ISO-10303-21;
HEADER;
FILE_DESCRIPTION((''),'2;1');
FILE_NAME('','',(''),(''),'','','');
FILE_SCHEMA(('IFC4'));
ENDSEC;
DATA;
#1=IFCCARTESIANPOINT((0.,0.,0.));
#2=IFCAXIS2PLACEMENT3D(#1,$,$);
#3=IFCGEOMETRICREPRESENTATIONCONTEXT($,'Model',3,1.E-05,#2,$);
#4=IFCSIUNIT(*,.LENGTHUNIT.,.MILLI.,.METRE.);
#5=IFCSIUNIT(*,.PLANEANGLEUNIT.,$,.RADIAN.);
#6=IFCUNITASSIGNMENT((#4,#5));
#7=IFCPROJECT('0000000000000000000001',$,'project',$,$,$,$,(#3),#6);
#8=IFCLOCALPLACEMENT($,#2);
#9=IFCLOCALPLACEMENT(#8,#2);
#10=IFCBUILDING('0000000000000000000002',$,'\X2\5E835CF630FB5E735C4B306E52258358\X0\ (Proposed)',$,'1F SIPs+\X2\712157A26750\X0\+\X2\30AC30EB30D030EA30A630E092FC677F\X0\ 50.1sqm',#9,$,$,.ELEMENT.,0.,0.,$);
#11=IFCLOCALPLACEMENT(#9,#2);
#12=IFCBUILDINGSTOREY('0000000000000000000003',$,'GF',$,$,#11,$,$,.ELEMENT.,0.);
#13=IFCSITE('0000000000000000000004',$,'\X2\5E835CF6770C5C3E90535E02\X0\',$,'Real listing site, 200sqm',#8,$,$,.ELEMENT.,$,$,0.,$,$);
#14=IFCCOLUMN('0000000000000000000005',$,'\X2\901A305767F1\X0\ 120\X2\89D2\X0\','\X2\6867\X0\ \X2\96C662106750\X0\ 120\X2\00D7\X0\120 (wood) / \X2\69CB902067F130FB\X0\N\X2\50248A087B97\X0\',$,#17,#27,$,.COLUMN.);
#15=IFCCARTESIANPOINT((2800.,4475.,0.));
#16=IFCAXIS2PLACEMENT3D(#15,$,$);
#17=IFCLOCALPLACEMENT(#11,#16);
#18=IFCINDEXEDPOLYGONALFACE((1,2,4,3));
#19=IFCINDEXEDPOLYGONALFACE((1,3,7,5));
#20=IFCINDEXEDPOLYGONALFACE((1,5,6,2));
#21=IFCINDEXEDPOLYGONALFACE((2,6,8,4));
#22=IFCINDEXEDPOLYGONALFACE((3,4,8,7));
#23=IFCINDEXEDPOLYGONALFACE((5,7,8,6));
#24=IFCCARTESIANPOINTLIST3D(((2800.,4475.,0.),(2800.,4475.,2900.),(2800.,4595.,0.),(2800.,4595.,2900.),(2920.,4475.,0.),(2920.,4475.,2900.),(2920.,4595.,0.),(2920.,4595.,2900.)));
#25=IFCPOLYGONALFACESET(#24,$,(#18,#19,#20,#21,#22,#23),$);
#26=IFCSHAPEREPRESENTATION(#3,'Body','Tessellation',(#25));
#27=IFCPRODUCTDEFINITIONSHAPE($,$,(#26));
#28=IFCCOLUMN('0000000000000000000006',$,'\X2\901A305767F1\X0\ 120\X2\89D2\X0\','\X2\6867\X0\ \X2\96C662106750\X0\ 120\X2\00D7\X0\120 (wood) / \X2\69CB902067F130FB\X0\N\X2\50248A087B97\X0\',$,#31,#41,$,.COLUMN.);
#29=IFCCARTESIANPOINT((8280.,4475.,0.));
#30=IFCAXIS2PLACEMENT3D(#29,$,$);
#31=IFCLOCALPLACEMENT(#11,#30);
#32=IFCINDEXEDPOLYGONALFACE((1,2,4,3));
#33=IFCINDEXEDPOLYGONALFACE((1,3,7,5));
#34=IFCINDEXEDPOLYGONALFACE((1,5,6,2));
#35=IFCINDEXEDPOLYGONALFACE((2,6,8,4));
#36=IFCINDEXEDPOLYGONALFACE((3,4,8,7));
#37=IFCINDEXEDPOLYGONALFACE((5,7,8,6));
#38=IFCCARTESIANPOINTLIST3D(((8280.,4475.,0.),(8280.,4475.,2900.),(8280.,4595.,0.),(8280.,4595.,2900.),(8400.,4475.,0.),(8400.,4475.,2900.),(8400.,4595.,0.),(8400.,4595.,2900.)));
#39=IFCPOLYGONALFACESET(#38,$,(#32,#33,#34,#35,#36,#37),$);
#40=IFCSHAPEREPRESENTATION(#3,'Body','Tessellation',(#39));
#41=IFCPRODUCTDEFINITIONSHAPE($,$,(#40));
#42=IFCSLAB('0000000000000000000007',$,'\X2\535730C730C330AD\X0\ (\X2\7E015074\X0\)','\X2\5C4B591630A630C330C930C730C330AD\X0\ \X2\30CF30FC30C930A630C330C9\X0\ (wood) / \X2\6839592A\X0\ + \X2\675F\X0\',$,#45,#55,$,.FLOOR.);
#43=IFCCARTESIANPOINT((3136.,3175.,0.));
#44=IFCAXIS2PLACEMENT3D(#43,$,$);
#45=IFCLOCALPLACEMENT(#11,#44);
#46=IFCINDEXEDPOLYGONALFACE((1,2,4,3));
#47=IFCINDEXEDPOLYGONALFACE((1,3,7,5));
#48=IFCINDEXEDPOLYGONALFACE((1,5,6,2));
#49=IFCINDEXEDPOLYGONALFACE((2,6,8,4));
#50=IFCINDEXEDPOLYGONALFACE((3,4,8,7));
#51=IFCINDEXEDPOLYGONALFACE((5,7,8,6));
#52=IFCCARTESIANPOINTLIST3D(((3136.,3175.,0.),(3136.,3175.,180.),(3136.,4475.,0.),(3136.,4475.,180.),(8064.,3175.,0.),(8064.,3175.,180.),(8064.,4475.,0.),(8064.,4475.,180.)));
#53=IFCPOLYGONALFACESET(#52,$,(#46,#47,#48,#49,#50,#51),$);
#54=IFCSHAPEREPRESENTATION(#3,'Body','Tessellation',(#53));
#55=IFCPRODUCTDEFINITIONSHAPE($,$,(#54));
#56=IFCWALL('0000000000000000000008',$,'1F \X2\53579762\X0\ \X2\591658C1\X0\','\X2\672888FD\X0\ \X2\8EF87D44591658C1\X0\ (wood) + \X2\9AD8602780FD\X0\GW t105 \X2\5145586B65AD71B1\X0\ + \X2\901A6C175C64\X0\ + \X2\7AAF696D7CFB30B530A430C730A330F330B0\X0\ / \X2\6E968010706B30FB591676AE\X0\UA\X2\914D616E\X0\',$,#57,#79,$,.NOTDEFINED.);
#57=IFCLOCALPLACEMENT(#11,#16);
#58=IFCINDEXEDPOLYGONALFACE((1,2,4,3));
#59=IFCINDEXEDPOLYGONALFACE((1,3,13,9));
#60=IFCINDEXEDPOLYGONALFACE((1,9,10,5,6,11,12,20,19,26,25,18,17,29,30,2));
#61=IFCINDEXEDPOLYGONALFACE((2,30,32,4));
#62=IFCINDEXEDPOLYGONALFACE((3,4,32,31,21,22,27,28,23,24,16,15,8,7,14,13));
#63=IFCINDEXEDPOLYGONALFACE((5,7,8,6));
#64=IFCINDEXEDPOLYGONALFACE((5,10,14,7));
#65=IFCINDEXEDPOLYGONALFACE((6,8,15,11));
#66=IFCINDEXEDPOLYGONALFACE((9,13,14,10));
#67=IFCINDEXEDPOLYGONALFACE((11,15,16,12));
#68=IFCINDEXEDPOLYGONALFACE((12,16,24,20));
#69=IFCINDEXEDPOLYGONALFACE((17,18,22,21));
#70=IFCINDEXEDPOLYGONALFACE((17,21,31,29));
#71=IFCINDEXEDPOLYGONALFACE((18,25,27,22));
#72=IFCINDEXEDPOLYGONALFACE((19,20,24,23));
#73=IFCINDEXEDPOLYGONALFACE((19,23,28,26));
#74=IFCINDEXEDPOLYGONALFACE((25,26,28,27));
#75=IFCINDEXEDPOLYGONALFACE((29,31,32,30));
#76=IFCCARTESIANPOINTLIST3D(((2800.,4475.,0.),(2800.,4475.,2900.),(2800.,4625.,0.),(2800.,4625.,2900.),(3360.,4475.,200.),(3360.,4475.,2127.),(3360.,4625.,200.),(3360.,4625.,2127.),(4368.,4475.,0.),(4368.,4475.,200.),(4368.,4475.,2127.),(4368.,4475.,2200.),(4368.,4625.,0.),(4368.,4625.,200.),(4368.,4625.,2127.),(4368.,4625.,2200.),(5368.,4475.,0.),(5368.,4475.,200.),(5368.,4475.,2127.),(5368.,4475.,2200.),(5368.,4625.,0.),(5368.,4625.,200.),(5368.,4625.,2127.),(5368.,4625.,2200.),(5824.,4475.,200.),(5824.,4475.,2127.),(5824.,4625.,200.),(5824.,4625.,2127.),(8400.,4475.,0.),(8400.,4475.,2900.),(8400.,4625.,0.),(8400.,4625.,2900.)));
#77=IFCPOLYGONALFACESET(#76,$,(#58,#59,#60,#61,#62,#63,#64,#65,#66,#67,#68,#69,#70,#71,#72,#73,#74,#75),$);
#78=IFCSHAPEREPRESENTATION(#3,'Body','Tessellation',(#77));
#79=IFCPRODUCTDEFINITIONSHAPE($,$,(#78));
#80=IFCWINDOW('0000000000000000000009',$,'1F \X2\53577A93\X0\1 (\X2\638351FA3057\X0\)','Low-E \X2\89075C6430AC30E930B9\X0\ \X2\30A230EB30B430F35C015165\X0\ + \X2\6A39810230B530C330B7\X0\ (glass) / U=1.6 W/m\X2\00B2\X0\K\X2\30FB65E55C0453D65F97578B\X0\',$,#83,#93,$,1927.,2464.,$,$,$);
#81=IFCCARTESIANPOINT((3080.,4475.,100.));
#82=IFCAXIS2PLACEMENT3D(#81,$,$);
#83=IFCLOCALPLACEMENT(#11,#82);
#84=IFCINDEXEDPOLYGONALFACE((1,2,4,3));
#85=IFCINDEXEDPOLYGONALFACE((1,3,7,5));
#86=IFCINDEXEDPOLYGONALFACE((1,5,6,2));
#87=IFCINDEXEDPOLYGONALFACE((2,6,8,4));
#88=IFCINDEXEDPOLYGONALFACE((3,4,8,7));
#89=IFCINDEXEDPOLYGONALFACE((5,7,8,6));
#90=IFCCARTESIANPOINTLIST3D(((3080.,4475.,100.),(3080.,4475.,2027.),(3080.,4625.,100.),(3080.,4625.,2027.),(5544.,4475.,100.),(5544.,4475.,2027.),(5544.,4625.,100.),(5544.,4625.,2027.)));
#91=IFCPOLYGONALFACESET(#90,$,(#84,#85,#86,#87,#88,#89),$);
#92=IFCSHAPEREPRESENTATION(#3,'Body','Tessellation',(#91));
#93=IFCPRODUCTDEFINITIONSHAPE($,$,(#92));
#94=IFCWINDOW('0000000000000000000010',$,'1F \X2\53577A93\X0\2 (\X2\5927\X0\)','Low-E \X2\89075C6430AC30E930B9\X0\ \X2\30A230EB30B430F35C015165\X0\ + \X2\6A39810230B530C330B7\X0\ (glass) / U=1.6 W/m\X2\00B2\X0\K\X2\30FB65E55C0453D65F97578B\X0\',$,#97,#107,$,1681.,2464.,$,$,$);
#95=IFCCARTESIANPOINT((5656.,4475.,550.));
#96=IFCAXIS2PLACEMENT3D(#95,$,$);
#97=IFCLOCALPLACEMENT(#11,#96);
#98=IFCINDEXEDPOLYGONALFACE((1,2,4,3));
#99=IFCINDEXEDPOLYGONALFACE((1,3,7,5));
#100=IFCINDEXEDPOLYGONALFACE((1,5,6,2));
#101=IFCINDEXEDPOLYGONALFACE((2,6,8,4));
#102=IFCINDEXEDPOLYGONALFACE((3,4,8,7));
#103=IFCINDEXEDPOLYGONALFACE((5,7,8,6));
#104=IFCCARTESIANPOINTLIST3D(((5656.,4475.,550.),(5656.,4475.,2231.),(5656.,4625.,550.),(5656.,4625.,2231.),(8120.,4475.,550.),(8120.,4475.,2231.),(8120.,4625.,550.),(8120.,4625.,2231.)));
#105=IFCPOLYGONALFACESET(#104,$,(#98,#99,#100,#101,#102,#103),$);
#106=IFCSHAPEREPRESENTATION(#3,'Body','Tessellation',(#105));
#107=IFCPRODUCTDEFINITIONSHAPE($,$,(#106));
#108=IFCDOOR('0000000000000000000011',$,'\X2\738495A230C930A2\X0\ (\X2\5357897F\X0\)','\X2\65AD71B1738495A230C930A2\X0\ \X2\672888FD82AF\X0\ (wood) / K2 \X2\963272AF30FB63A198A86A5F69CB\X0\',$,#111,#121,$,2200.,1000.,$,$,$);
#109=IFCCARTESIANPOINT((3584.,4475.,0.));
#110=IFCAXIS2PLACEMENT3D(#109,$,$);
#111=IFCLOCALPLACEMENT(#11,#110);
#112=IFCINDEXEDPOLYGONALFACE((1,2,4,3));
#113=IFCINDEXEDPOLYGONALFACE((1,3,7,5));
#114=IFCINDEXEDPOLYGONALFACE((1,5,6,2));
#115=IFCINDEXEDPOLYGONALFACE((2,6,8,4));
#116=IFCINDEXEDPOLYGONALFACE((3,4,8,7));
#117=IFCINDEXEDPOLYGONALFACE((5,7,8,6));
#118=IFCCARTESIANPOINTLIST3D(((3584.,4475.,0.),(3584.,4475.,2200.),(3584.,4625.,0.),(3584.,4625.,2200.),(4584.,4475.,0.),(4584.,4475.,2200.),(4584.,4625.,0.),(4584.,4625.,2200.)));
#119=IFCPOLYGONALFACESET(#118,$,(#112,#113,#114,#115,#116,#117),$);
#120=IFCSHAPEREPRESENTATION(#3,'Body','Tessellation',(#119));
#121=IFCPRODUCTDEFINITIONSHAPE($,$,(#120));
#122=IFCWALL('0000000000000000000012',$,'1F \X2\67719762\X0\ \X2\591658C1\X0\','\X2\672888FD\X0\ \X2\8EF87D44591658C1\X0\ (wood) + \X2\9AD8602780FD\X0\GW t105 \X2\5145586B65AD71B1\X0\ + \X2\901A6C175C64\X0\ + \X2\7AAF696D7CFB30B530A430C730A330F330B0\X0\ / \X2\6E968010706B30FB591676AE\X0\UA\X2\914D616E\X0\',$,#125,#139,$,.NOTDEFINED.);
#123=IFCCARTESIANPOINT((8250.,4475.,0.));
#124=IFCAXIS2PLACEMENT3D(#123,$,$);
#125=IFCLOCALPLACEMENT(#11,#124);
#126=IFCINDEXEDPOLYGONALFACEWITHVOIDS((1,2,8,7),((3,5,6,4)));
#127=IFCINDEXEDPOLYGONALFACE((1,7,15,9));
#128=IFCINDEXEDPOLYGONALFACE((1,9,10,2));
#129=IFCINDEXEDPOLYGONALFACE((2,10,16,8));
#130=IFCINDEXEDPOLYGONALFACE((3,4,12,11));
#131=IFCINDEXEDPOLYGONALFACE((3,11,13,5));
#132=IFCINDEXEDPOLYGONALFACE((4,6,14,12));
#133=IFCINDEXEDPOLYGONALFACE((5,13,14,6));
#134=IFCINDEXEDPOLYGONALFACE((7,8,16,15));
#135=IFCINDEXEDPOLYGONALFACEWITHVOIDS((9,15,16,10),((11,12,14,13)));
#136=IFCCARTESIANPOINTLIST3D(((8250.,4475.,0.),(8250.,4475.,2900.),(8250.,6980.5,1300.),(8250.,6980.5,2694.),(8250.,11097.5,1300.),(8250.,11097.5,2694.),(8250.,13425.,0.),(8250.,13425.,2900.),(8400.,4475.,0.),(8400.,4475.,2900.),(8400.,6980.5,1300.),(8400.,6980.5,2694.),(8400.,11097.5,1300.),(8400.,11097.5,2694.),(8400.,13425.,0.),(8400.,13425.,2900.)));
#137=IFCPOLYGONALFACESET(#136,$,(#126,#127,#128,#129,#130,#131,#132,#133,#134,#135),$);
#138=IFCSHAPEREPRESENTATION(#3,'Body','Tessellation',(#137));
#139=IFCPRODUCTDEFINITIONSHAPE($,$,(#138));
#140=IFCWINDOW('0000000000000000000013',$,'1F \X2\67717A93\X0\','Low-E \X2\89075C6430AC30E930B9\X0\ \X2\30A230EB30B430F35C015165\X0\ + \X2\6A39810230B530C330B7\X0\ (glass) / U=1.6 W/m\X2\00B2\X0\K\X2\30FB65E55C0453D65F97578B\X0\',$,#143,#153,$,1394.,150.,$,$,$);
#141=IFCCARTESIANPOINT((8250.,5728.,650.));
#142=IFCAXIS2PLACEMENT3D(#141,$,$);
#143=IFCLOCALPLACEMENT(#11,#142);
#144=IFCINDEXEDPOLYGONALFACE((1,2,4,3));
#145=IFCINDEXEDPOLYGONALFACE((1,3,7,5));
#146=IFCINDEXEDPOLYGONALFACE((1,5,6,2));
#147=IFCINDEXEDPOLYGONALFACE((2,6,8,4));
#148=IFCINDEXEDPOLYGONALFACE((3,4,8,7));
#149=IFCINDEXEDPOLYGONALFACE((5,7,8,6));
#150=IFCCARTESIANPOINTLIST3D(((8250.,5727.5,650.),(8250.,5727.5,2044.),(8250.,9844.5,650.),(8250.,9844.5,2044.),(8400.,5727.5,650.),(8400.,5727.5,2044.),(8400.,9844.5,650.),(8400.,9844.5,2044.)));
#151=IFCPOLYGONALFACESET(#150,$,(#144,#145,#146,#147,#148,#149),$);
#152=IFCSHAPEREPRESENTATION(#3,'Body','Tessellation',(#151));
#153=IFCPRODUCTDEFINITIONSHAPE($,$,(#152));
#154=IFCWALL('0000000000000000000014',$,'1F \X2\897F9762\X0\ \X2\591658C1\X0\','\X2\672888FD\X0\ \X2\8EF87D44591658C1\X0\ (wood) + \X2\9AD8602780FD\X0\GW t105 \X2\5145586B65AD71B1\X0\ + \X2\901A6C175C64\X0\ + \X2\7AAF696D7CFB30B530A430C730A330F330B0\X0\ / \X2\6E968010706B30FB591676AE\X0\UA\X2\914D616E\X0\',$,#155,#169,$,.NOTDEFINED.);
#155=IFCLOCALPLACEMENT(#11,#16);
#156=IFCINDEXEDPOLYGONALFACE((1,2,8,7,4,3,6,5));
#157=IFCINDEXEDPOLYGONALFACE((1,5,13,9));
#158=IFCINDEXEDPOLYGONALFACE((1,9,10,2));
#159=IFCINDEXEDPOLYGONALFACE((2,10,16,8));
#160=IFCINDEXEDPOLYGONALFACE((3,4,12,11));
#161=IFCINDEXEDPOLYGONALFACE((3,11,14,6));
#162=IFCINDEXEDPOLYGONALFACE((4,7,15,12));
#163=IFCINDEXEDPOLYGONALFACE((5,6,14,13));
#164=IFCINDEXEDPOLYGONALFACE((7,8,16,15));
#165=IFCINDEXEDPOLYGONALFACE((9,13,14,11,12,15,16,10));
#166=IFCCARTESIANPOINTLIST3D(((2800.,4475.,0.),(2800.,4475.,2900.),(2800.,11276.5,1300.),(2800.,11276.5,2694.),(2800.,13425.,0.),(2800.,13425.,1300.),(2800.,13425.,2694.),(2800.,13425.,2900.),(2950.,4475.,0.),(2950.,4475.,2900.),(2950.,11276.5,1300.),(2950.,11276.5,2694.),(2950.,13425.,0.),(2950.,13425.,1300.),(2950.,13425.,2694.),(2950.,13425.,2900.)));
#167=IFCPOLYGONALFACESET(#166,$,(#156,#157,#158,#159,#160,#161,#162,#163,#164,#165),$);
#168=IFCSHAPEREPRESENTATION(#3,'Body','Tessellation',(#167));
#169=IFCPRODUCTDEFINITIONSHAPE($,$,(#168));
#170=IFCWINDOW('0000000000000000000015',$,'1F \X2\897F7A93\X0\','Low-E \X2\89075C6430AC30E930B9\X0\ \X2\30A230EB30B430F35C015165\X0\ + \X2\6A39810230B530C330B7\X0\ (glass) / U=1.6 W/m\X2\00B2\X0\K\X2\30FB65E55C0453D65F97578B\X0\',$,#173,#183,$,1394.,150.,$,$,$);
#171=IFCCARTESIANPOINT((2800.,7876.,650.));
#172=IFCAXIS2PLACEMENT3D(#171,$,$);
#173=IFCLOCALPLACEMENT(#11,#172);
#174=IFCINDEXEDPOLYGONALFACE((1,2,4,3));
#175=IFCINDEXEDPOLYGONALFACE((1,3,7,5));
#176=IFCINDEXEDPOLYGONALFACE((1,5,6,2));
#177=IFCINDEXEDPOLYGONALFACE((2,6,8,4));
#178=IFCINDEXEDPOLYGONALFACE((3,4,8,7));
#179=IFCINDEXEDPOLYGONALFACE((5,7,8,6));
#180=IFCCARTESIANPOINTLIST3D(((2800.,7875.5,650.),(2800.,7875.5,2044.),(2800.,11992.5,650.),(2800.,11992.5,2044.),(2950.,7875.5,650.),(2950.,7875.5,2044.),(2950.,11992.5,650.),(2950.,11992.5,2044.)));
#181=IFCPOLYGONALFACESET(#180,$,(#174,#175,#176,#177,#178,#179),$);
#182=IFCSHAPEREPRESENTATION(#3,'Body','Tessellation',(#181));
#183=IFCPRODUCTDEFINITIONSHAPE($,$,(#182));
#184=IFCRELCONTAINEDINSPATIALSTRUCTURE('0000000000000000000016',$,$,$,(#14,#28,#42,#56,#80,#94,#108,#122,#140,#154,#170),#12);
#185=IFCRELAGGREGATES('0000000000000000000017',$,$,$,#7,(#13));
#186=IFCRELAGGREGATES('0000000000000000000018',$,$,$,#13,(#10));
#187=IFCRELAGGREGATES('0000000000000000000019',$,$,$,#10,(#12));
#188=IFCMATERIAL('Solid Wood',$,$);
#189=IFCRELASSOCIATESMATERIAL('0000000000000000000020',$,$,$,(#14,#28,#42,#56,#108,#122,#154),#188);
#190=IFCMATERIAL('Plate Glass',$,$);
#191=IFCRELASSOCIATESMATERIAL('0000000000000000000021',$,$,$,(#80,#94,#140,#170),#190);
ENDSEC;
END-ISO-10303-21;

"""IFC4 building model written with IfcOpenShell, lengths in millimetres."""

from ifc_helpers import new_model, si_unit, frame, frame_2d, origin, place, context, project, spatial, rectangle, extrude, material, element, fill, save


model = new_model("IFC4")

# Units and contexts
model_context = context("Model", 3, precision=1e-05, world=origin())
ifc_project = project(units=[si_unit("LENGTHUNIT", "METRE", prefix="MILLI"), si_unit("PLANEANGLEUNIT", "RADIAN")], contexts=[model_context])

# Site, building, storey
site_placement = place(None, origin())
site = spatial("IfcSite", under=ifc_project, at=site_placement, Name="広島県尾道市", ObjectType="Real listing site, 200sqm", CompositionType="ELEMENT", RefElevation=0.0)
building_placement = place(site_placement, origin())
building = spatial("IfcBuilding", under=site, at=building_placement, Name="広島・平屋の別荘 (Proposed)", ObjectType="1F SIPs+無垢材+ガルバリウム鋼板 50.1sqm", CompositionType="ELEMENT", ElevationOfRefHeight=0.0, ElevationOfTerrain=0.0)
storey_placement = place(building_placement, origin())
storey = spatial("IfcBuildingStorey", under=building, at=storey_placement, Name="GF", CompositionType="ELEMENT", Elevation=0.0)

# Columns
ifc_material_1 = material(Name="Solid Wood")
column_1_placement = place(storey_placement, frame((2800.0, 4475.0, 0.0)))
element("IfcColumn", 1, at=column_1_placement, inside=storey, material=ifc_material_1, Name="通し柱 120角", Description="桧 集成材 120×120 (wood) / 構造柱・N値計算", PredefinedType="COLUMN", context=model_context, shape_type="SweptSolid", body=[
    extrude(rectangle(XDim=120.0, YDim=120.0, at=frame_2d((60.0, 60.0))), frame((2800.0, 4475.0, 0.0)), (0.0, 0.0, 1.0), 2900.0),
])
column_2_placement = place(storey_placement, frame((8280.0, 4475.0, 0.0)))
element("IfcColumn", 2, at=column_2_placement, inside=storey, material=ifc_material_1, Name="通し柱 120角", Description="桧 集成材 120×120 (wood) / 構造柱・N値計算", PredefinedType="COLUMN", context=model_context, shape_type="SweptSolid", body=[
    extrude(rectangle(XDim=120.0, YDim=120.0, at=frame_2d((60.0, 60.0))), frame((8280.0, 4475.0, 0.0)), (0.0, 0.0, 1.0), 2900.0),
])

# Slab
slab_1_placement = place(storey_placement, frame((3136.0, 3175.0, 0.0)))
element("IfcSlab", 3, at=slab_1_placement, inside=storey, material=ifc_material_1, Name="南デッキ (縁側)", Description="屋外ウッドデッキ ハードウッド (wood) / 根太 + 束", PredefinedType="FLOOR", context=model_context, shape_type="SweptSolid", body=[
    extrude(rectangle(XDim=4928.0, YDim=1300.0, at=frame_2d((2464.0, 650.0))), frame((3136.0, 3175.0, 0.0)), (0.0, 0.0, 1.0), 180.0),
])

# Wall, openings, windows, door
wall_1_placement = place(storey_placement, frame((2800.0, 4475.0, 0.0)))
wall_1 = element("IfcWall", 4, at=wall_1_placement, inside=storey, material=ifc_material_1, Name="1F 南面 外壁", Description="木製 軸組外壁 (wood) + 高性能GW t105 充填断熱 + 通気層 + 窯業系サイディング / 準耐火・外皮UA配慮", PredefinedType="NOTDEFINED", context=model_context, shape_type="SweptSolid", body=[
    extrude(rectangle(XDim=5600.0, YDim=150.0, at=frame_2d((2800.0, 75.0))), frame((2800.0, 4475.0, 0.0)), (0.0, 0.0, 1.0), 2900.0),
])
opening_1_placement = place(storey_placement, frame((3080.0, 4475.0, 100.0)))
opening_1 = element("IfcOpeningElement", 5, at=opening_1_placement, cuts=wall_1, PredefinedType="NOTDEFINED", context=model_context, shape_type="SweptSolid", body=[
    extrude(rectangle(XDim=2464.0, YDim=150.0, at=frame_2d((1232.0, 75.0))), frame((3080.0, 4475.0, 100.0)), (0.0, 0.0, 1.0), 1927.0),
])
opening_2_placement = place(storey_placement, frame((5656.0, 4475.0, 550.0)))
opening_2 = element("IfcOpeningElement", 6, at=opening_2_placement, cuts=wall_1, PredefinedType="NOTDEFINED", context=model_context, shape_type="SweptSolid", body=[
    extrude(rectangle(XDim=2464.0, YDim=150.0, at=frame_2d((1232.0, 75.0))), frame((5656.0, 4475.0, 550.0)), (0.0, 0.0, 1.0), 1681.0),
])
opening_3_placement = place(storey_placement, frame((3584.0, 4475.0, 0.0)))
opening_3 = element("IfcOpeningElement", 7, at=opening_3_placement, cuts=wall_1, PredefinedType="NOTDEFINED", context=model_context, shape_type="SweptSolid", body=[
    extrude(rectangle(XDim=1000.0, YDim=150.0, at=frame_2d((500.0, 75.0))), frame((3584.0, 4475.0, 0.0)), (0.0, 0.0, 1.0), 2200.0),
])
ifc_material_2 = material(Name="Plate Glass")
window_1_placement = place(storey_placement, frame((3080.0, 4475.0, 100.0)))
window_1 = element("IfcWindow", 8, at=window_1_placement, inside=storey, material=ifc_material_2, Name="1F 南窓1 (掃出し)", Description="Low-E 複層ガラス アルゴン封入 + 樹脂サッシ (glass) / U=1.6 W/m²K・日射取得型", OverallHeight=1927.0, OverallWidth=2464.0, context=model_context, shape_type="SweptSolid", body=[
    extrude(rectangle(XDim=2464.0, YDim=150.0, at=frame_2d((1232.0, 75.0))), frame((3080.0, 4475.0, 100.0)), (0.0, 0.0, 1.0), 1927.0),
])
fill(opening_1, window_1)
window_2_placement = place(storey_placement, frame((5656.0, 4475.0, 550.0)))
window_2 = element("IfcWindow", 9, at=window_2_placement, inside=storey, material=ifc_material_2, Name="1F 南窓2 (大)", Description="Low-E 複層ガラス アルゴン封入 + 樹脂サッシ (glass) / U=1.6 W/m²K・日射取得型", OverallHeight=1681.0, OverallWidth=2464.0, context=model_context, shape_type="SweptSolid", body=[
    extrude(rectangle(XDim=2464.0, YDim=150.0, at=frame_2d((1232.0, 75.0))), frame((5656.0, 4475.0, 550.0)), (0.0, 0.0, 1.0), 1681.0),
])
fill(opening_2, window_2)
door_placement = place(storey_placement, frame((3584.0, 4475.0, 0.0)))
door = element("IfcDoor", 10, at=door_placement, inside=storey, material=ifc_material_1, Name="玄関ドア (南西)", Description="断熱玄関ドア 木製芯 (wood) / K2 防犯・採風機構", OverallHeight=2200.0, OverallWidth=1000.0, context=model_context, shape_type="SweptSolid", body=[
    extrude(rectangle(XDim=1000.0, YDim=150.0, at=frame_2d((500.0, 75.0))), frame((3584.0, 4475.0, 0.0)), (0.0, 0.0, 1.0), 2200.0),
])
fill(opening_3, door)

# Walls, openings, windows
wall_2_placement = place(storey_placement, frame((8250.0, 4475.0, 0.0)))
wall_2 = element("IfcWall", 11, at=wall_2_placement, inside=storey, material=ifc_material_1, Name="1F 東面 外壁", Description="木製 軸組外壁 (wood) + 高性能GW t105 充填断熱 + 通気層 + 窯業系サイディング / 準耐火・外皮UA配慮", PredefinedType="NOTDEFINED", context=model_context, shape_type="SweptSolid", body=[
    extrude(rectangle(XDim=150.0, YDim=8950.0, at=frame_2d((75.0, 4475.0))), frame((8250.0, 4475.0, 0.0)), (0.0, 0.0, 1.0), 2900.0),
])
opening_4_placement = place(storey_placement, frame((8250.0, 5728.0, 650.0)))
opening_4 = element("IfcOpeningElement", 12, at=opening_4_placement, cuts=wall_2, PredefinedType="NOTDEFINED", context=model_context, shape_type="SweptSolid", body=[
    extrude(rectangle(XDim=150.0, YDim=4117.0, at=frame_2d((75.0, 2058.0))), frame((8250.0, 5728.0, 650.0)), (0.0, 0.0, 1.0), 1394.0),
])
window_3_placement = place(storey_placement, frame((8250.0, 5728.0, 650.0)))
window_3 = element("IfcWindow", 13, at=window_3_placement, inside=storey, material=ifc_material_2, Name="1F 東窓", Description="Low-E 複層ガラス アルゴン封入 + 樹脂サッシ (glass) / U=1.6 W/m²K・日射取得型", OverallHeight=1394.0, OverallWidth=150.0, context=model_context, shape_type="SweptSolid", body=[
    extrude(rectangle(XDim=150.0, YDim=4117.0, at=frame_2d((75.0, 2058.0))), frame((8250.0, 5728.0, 650.0)), (0.0, 0.0, 1.0), 1394.0),
])
fill(opening_4, window_3)
wall_3_placement = place(storey_placement, frame((2800.0, 4475.0, 0.0)))
wall_3 = element("IfcWall", 14, at=wall_3_placement, inside=storey, material=ifc_material_1, Name="1F 西面 外壁", Description="木製 軸組外壁 (wood) + 高性能GW t105 充填断熱 + 通気層 + 窯業系サイディング / 準耐火・外皮UA配慮", PredefinedType="NOTDEFINED", context=model_context, shape_type="SweptSolid", body=[
    extrude(rectangle(XDim=150.0, YDim=8950.0, at=frame_2d((75.0, 4475.0))), frame((2800.0, 4475.0, 0.0)), (0.0, 0.0, 1.0), 2900.0),
])
opening_5_placement = place(storey_placement, frame((2800.0, 7876.0, 650.0)))
opening_5 = element("IfcOpeningElement", 15, at=opening_5_placement, cuts=wall_3, PredefinedType="NOTDEFINED", context=model_context, shape_type="SweptSolid", body=[
    extrude(rectangle(XDim=150.0, YDim=4117.0, at=frame_2d((75.0, 2058.0))), frame((2800.0, 7876.0, 650.0)), (0.0, 0.0, 1.0), 1394.0),
])
window_4_placement = place(storey_placement, frame((2800.0, 7876.0, 650.0)))
window_4 = element("IfcWindow", 16, at=window_4_placement, inside=storey, material=ifc_material_2, Name="1F 西窓", Description="Low-E 複層ガラス アルゴン封入 + 樹脂サッシ (glass) / U=1.6 W/m²K・日射取得型", OverallHeight=1394.0, OverallWidth=150.0, context=model_context, shape_type="SweptSolid", body=[
    extrude(rectangle(XDim=150.0, YDim=4117.0, at=frame_2d((75.0, 2058.0))), frame((2800.0, 7876.0, 650.0)), (0.0, 0.0, 1.0), 1394.0),
])
fill(opening_5, window_4)

save(model, "model.ifc")
